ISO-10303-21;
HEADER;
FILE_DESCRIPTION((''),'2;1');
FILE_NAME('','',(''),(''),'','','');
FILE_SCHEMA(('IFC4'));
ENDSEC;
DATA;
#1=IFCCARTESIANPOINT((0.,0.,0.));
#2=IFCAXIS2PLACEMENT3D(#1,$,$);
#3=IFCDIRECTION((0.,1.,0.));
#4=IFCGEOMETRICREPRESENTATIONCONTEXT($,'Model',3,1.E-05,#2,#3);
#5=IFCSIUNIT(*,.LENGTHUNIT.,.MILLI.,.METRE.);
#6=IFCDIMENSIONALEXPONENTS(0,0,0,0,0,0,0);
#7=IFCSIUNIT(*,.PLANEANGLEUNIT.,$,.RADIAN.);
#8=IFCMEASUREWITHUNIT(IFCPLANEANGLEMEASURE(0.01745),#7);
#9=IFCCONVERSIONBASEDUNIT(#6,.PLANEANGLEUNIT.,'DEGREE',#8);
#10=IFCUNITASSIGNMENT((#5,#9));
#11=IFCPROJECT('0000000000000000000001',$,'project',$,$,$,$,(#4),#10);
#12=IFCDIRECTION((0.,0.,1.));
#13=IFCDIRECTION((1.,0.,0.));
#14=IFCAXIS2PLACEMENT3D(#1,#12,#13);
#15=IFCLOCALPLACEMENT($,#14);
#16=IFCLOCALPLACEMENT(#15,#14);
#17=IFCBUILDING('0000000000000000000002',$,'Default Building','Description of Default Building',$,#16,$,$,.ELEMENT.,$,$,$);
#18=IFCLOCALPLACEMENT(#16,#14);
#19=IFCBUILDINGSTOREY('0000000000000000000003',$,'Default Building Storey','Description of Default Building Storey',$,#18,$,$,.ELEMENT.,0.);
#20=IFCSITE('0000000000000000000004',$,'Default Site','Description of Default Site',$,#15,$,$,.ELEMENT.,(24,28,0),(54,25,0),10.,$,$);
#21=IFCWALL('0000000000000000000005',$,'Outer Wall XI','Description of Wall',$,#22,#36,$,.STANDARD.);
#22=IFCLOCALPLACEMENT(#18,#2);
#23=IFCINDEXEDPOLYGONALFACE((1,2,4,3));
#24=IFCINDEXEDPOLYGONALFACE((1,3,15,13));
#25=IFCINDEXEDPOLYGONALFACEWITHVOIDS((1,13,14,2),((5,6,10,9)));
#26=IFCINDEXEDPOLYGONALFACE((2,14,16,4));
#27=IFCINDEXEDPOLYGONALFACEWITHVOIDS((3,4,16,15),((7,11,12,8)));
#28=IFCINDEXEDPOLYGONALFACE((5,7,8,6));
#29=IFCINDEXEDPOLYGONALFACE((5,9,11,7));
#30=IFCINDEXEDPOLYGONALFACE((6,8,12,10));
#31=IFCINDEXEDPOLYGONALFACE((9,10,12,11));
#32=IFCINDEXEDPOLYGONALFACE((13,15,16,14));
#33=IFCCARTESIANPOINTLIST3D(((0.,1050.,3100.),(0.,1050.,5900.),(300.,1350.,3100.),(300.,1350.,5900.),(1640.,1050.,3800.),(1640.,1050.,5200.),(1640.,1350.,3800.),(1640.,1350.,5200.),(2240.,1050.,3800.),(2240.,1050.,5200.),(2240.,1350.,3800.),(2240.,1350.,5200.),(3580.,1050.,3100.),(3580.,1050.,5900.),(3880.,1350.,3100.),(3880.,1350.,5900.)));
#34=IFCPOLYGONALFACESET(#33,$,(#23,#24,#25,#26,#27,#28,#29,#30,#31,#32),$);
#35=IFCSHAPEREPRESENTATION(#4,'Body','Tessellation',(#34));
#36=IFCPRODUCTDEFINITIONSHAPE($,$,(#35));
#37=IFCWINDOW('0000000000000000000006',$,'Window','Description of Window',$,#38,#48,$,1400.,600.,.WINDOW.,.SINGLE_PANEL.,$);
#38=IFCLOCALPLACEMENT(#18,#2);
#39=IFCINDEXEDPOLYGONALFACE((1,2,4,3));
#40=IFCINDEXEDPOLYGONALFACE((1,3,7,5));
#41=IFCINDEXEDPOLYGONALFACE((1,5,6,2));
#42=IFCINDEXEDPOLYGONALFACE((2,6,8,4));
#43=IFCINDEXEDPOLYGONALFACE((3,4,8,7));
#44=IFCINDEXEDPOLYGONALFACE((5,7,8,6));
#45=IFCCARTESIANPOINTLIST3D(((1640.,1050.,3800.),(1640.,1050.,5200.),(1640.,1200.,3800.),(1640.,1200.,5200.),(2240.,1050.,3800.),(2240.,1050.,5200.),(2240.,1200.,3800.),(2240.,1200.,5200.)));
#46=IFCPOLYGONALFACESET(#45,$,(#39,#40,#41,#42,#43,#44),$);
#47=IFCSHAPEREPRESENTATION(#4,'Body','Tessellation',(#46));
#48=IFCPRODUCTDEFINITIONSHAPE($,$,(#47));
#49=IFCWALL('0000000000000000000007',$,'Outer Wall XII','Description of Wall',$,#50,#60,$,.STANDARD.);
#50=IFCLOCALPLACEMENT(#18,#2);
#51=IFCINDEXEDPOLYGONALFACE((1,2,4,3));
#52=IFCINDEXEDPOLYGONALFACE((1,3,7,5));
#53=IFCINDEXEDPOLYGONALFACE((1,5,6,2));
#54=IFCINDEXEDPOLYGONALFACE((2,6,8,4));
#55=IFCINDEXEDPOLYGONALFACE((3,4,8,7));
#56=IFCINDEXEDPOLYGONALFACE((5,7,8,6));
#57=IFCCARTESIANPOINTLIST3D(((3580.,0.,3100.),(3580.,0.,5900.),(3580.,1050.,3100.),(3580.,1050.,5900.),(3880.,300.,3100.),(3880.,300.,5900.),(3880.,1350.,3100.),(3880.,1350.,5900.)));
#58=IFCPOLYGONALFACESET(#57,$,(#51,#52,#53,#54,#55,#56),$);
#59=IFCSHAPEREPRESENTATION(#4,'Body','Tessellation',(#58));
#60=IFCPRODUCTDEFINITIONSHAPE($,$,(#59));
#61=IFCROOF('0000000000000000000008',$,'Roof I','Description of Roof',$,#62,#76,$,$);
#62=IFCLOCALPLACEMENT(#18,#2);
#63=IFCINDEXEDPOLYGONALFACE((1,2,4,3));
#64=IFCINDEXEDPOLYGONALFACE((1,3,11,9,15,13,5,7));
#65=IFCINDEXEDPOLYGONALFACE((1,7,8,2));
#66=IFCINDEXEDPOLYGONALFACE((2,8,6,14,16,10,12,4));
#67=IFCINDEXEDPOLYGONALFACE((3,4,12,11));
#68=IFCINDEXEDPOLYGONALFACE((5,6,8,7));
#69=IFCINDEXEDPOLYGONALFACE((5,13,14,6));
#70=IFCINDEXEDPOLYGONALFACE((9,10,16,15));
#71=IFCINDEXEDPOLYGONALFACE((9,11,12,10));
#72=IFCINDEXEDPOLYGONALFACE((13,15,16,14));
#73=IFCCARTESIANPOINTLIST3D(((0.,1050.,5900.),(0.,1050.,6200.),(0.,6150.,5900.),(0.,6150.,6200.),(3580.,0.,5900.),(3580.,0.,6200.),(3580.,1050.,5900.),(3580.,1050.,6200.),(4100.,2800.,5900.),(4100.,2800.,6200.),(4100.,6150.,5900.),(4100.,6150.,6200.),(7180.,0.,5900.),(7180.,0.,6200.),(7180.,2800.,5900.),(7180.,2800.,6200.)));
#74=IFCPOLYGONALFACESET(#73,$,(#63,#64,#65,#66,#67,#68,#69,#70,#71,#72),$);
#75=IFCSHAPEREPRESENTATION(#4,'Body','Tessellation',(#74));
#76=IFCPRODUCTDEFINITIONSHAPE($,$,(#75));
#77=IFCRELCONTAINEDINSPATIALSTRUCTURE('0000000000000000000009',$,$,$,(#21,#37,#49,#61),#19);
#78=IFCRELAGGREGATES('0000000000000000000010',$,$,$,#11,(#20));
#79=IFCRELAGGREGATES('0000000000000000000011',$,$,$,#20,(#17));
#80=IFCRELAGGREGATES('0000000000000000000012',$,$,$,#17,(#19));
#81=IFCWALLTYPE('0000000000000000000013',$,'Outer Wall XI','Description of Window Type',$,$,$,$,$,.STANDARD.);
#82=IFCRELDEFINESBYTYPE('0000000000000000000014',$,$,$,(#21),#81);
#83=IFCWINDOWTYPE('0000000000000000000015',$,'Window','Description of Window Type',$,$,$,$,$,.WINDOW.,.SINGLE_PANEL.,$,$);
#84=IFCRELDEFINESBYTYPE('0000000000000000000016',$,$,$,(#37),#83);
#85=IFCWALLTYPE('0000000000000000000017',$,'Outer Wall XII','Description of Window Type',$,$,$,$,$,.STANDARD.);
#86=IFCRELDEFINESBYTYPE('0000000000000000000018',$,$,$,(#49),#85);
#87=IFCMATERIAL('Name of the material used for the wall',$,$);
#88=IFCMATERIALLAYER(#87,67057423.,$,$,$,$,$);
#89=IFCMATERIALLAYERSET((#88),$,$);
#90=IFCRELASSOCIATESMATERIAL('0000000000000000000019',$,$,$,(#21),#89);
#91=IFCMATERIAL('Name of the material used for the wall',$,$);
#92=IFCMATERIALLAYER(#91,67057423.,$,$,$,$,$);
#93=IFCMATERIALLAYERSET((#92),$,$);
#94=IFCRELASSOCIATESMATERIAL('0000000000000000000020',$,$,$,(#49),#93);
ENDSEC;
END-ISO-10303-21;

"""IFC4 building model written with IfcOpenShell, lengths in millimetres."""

from ifc_helpers import new_model, entity, si_unit, converted_unit, direction, frame, origin, origin_with_axes, place, context, project, spatial, polyline, outline, extrude, material, layer, layer_set, layer_usage, type_object, element, fill, save


model = new_model("IFC4")

# Units and contexts
model_context = context("Model", 3, precision=1e-05, world=origin(), true_north=direction((0.0, 1.0, 0.0)))
ifc_project = project(units=[si_unit("LENGTHUNIT", "METRE", prefix="MILLI"), converted_unit("PLANEANGLEUNIT", "DEGREE", entity("IfcPlaneAngleMeasure", 0.01745), si_unit("PLANEANGLEUNIT", "RADIAN"), dimensions=[0, 0, 0, 0, 0, 0, 0])], contexts=[model_context])

# Site, building, storey
site_placement = place(None, origin_with_axes())
site = spatial("IfcSite", under=ifc_project, at=site_placement, Name="Default Site", Description="Description of Default Site", CompositionType="ELEMENT", RefLatitude=(24, 28, 0), RefLongitude=(54, 25, 0), RefElevation=10.0)
building_placement = place(site_placement, origin_with_axes())
building = spatial("IfcBuilding", under=site, at=building_placement, Name="Default Building", Description="Description of Default Building", CompositionType="ELEMENT")
storey_placement = place(building_placement, origin_with_axes())
storey = spatial("IfcBuildingStorey", under=building, at=storey_placement, Name="Default Building Storey", Description="Description of Default Building Storey", CompositionType="ELEMENT", Elevation=0.0)

# Wall, opening, window
ifc_material_1 = material(Name="Name of the material used for the wall")
ifc_layer_1 = layer(ifc_material_1, 67057423.0)
ifc_layer_set_1 = layer_set([ifc_layer_1])
ifc_layer_usage_1 = layer_usage(ifc_layer_set_1, "AXIS2", "POSITIVE", -33528711.5)
wall_type_1 = type_object("IfcWallType", Name="Outer Wall XI", Description="Description of Window Type", PredefinedType="STANDARD")
wall_1_placement = place(storey_placement, frame((150.0, 1200.0, 3100.0), z_axis=(0.0, 0.0, 1.0), x_axis=(1.0, 0.0, 0.0)))
wall_1 = element("IfcWall", 1, at=wall_1_placement, inside=storey, type_object=wall_type_1, material=ifc_layer_usage_1, Name="Outer Wall XI", Description="Description of Wall", PredefinedType="STANDARD", context=model_context, shape_type="SweptSolid", body=[
    extrude(outline(polyline([(-150.0, -150.0), (150.0, 150.0), (3730.0, 150.0), (3430.0, -150.0), (-150.0, -150.0)])), origin_with_axes(), (0.0, 0.0, 1.0), 2800.0),
])
opening_1_placement = place(wall_1_placement, frame((1490.0, -150.0, 700.0), z_axis=(0.0, 0.0, 1.0), x_axis=(1.0, 0.0, 0.0)))
opening_1 = element("IfcOpeningElement", 2, at=opening_1_placement, cuts=wall_1, context=model_context, shape_type="SweptSolid", body=[
    extrude(outline(polyline([(0.0, 0.0), (0.0, 300.0), (600.0, 300.0), (600.0, 0.0), (0.0, 0.0)])), origin_with_axes(), (0.0, 0.0, 1.0), 1400.0),
])
window_type_1 = type_object("IfcWindowType", Name="Window", Description="Description of Window Type", PartitioningType="SINGLE_PANEL", PredefinedType="WINDOW")
window_1_placement = place(opening_1_placement, origin_with_axes())
window_1 = element("IfcWindow", 3, at=window_1_placement, inside=storey, type_object=window_type_1, Name="Window", Description="Description of Window", OverallHeight=1400.0, OverallWidth=600.0, PartitioningType="SINGLE_PANEL", PredefinedType="WINDOW", context=model_context, shape_type="SweptSolid", body=[
    extrude(outline(polyline([(0.0, 0.0), (0.0, 150.0), (600.0, 150.0), (600.0, 0.0), (0.0, 0.0)])), origin_with_axes(), (0.0, 0.0, 1.0), 1400.0),
])
fill(opening_1, window_1)

# Wall
ifc_material_2 = material(Name="Name of the material used for the wall")
ifc_layer_2 = layer(ifc_material_2, 67057423.0)
ifc_layer_set_2 = layer_set([ifc_layer_2])
ifc_layer_usage_2 = layer_usage(ifc_layer_set_2, "AXIS2", "POSITIVE", -33528711.5)
wall_type_2 = type_object("IfcWallType", Name="Outer Wall XII", Description="Description of Window Type", PredefinedType="STANDARD")
wall_2_placement = place(storey_placement, frame((3730.0, 1200.0, 3100.0), z_axis=(0.0, 0.0, 1.0), x_axis=(0.0, -1.0, 0.0)))
element("IfcWall", 4, at=wall_2_placement, inside=storey, type_object=wall_type_2, material=ifc_layer_usage_2, Name="Outer Wall XII", Description="Description of Wall", PredefinedType="STANDARD", context=model_context, shape_type="SweptSolid", body=[
    extrude(outline(polyline([(150.0, -150.0), (-150.0, 150.0), (900.0, 150.0), (1200.0, -150.0), (150.0, -150.0)])), origin_with_axes(), (0.0, 0.0, 1.0), 2800.0),
])

# Roof
roof_placement = place(storey_placement, frame((0.0, 0.0, 5900.0), z_axis=(0.0, 0.0, 1.0), x_axis=(1.0, 0.0, 0.0)))
element("IfcRoof", 5, at=roof_placement, inside=storey, Name="Roof I", Description="Description of Roof", context=model_context, shape_type="SweptSolid", body=[
    extrude(outline(polyline([(0.0, 1050.0), (0.0, 6150.0), (4100.0, 6150.0), (4100.0, 2800.0), (7180.0, 2800.0), (7180.0, 0.0), (3580.0, 0.0), (3580.0, 1050.0), (0.0, 1050.0)])), origin_with_axes(), (0.0, 0.0, 1.0), 300.0),
])

save(model, "model.ifc")
